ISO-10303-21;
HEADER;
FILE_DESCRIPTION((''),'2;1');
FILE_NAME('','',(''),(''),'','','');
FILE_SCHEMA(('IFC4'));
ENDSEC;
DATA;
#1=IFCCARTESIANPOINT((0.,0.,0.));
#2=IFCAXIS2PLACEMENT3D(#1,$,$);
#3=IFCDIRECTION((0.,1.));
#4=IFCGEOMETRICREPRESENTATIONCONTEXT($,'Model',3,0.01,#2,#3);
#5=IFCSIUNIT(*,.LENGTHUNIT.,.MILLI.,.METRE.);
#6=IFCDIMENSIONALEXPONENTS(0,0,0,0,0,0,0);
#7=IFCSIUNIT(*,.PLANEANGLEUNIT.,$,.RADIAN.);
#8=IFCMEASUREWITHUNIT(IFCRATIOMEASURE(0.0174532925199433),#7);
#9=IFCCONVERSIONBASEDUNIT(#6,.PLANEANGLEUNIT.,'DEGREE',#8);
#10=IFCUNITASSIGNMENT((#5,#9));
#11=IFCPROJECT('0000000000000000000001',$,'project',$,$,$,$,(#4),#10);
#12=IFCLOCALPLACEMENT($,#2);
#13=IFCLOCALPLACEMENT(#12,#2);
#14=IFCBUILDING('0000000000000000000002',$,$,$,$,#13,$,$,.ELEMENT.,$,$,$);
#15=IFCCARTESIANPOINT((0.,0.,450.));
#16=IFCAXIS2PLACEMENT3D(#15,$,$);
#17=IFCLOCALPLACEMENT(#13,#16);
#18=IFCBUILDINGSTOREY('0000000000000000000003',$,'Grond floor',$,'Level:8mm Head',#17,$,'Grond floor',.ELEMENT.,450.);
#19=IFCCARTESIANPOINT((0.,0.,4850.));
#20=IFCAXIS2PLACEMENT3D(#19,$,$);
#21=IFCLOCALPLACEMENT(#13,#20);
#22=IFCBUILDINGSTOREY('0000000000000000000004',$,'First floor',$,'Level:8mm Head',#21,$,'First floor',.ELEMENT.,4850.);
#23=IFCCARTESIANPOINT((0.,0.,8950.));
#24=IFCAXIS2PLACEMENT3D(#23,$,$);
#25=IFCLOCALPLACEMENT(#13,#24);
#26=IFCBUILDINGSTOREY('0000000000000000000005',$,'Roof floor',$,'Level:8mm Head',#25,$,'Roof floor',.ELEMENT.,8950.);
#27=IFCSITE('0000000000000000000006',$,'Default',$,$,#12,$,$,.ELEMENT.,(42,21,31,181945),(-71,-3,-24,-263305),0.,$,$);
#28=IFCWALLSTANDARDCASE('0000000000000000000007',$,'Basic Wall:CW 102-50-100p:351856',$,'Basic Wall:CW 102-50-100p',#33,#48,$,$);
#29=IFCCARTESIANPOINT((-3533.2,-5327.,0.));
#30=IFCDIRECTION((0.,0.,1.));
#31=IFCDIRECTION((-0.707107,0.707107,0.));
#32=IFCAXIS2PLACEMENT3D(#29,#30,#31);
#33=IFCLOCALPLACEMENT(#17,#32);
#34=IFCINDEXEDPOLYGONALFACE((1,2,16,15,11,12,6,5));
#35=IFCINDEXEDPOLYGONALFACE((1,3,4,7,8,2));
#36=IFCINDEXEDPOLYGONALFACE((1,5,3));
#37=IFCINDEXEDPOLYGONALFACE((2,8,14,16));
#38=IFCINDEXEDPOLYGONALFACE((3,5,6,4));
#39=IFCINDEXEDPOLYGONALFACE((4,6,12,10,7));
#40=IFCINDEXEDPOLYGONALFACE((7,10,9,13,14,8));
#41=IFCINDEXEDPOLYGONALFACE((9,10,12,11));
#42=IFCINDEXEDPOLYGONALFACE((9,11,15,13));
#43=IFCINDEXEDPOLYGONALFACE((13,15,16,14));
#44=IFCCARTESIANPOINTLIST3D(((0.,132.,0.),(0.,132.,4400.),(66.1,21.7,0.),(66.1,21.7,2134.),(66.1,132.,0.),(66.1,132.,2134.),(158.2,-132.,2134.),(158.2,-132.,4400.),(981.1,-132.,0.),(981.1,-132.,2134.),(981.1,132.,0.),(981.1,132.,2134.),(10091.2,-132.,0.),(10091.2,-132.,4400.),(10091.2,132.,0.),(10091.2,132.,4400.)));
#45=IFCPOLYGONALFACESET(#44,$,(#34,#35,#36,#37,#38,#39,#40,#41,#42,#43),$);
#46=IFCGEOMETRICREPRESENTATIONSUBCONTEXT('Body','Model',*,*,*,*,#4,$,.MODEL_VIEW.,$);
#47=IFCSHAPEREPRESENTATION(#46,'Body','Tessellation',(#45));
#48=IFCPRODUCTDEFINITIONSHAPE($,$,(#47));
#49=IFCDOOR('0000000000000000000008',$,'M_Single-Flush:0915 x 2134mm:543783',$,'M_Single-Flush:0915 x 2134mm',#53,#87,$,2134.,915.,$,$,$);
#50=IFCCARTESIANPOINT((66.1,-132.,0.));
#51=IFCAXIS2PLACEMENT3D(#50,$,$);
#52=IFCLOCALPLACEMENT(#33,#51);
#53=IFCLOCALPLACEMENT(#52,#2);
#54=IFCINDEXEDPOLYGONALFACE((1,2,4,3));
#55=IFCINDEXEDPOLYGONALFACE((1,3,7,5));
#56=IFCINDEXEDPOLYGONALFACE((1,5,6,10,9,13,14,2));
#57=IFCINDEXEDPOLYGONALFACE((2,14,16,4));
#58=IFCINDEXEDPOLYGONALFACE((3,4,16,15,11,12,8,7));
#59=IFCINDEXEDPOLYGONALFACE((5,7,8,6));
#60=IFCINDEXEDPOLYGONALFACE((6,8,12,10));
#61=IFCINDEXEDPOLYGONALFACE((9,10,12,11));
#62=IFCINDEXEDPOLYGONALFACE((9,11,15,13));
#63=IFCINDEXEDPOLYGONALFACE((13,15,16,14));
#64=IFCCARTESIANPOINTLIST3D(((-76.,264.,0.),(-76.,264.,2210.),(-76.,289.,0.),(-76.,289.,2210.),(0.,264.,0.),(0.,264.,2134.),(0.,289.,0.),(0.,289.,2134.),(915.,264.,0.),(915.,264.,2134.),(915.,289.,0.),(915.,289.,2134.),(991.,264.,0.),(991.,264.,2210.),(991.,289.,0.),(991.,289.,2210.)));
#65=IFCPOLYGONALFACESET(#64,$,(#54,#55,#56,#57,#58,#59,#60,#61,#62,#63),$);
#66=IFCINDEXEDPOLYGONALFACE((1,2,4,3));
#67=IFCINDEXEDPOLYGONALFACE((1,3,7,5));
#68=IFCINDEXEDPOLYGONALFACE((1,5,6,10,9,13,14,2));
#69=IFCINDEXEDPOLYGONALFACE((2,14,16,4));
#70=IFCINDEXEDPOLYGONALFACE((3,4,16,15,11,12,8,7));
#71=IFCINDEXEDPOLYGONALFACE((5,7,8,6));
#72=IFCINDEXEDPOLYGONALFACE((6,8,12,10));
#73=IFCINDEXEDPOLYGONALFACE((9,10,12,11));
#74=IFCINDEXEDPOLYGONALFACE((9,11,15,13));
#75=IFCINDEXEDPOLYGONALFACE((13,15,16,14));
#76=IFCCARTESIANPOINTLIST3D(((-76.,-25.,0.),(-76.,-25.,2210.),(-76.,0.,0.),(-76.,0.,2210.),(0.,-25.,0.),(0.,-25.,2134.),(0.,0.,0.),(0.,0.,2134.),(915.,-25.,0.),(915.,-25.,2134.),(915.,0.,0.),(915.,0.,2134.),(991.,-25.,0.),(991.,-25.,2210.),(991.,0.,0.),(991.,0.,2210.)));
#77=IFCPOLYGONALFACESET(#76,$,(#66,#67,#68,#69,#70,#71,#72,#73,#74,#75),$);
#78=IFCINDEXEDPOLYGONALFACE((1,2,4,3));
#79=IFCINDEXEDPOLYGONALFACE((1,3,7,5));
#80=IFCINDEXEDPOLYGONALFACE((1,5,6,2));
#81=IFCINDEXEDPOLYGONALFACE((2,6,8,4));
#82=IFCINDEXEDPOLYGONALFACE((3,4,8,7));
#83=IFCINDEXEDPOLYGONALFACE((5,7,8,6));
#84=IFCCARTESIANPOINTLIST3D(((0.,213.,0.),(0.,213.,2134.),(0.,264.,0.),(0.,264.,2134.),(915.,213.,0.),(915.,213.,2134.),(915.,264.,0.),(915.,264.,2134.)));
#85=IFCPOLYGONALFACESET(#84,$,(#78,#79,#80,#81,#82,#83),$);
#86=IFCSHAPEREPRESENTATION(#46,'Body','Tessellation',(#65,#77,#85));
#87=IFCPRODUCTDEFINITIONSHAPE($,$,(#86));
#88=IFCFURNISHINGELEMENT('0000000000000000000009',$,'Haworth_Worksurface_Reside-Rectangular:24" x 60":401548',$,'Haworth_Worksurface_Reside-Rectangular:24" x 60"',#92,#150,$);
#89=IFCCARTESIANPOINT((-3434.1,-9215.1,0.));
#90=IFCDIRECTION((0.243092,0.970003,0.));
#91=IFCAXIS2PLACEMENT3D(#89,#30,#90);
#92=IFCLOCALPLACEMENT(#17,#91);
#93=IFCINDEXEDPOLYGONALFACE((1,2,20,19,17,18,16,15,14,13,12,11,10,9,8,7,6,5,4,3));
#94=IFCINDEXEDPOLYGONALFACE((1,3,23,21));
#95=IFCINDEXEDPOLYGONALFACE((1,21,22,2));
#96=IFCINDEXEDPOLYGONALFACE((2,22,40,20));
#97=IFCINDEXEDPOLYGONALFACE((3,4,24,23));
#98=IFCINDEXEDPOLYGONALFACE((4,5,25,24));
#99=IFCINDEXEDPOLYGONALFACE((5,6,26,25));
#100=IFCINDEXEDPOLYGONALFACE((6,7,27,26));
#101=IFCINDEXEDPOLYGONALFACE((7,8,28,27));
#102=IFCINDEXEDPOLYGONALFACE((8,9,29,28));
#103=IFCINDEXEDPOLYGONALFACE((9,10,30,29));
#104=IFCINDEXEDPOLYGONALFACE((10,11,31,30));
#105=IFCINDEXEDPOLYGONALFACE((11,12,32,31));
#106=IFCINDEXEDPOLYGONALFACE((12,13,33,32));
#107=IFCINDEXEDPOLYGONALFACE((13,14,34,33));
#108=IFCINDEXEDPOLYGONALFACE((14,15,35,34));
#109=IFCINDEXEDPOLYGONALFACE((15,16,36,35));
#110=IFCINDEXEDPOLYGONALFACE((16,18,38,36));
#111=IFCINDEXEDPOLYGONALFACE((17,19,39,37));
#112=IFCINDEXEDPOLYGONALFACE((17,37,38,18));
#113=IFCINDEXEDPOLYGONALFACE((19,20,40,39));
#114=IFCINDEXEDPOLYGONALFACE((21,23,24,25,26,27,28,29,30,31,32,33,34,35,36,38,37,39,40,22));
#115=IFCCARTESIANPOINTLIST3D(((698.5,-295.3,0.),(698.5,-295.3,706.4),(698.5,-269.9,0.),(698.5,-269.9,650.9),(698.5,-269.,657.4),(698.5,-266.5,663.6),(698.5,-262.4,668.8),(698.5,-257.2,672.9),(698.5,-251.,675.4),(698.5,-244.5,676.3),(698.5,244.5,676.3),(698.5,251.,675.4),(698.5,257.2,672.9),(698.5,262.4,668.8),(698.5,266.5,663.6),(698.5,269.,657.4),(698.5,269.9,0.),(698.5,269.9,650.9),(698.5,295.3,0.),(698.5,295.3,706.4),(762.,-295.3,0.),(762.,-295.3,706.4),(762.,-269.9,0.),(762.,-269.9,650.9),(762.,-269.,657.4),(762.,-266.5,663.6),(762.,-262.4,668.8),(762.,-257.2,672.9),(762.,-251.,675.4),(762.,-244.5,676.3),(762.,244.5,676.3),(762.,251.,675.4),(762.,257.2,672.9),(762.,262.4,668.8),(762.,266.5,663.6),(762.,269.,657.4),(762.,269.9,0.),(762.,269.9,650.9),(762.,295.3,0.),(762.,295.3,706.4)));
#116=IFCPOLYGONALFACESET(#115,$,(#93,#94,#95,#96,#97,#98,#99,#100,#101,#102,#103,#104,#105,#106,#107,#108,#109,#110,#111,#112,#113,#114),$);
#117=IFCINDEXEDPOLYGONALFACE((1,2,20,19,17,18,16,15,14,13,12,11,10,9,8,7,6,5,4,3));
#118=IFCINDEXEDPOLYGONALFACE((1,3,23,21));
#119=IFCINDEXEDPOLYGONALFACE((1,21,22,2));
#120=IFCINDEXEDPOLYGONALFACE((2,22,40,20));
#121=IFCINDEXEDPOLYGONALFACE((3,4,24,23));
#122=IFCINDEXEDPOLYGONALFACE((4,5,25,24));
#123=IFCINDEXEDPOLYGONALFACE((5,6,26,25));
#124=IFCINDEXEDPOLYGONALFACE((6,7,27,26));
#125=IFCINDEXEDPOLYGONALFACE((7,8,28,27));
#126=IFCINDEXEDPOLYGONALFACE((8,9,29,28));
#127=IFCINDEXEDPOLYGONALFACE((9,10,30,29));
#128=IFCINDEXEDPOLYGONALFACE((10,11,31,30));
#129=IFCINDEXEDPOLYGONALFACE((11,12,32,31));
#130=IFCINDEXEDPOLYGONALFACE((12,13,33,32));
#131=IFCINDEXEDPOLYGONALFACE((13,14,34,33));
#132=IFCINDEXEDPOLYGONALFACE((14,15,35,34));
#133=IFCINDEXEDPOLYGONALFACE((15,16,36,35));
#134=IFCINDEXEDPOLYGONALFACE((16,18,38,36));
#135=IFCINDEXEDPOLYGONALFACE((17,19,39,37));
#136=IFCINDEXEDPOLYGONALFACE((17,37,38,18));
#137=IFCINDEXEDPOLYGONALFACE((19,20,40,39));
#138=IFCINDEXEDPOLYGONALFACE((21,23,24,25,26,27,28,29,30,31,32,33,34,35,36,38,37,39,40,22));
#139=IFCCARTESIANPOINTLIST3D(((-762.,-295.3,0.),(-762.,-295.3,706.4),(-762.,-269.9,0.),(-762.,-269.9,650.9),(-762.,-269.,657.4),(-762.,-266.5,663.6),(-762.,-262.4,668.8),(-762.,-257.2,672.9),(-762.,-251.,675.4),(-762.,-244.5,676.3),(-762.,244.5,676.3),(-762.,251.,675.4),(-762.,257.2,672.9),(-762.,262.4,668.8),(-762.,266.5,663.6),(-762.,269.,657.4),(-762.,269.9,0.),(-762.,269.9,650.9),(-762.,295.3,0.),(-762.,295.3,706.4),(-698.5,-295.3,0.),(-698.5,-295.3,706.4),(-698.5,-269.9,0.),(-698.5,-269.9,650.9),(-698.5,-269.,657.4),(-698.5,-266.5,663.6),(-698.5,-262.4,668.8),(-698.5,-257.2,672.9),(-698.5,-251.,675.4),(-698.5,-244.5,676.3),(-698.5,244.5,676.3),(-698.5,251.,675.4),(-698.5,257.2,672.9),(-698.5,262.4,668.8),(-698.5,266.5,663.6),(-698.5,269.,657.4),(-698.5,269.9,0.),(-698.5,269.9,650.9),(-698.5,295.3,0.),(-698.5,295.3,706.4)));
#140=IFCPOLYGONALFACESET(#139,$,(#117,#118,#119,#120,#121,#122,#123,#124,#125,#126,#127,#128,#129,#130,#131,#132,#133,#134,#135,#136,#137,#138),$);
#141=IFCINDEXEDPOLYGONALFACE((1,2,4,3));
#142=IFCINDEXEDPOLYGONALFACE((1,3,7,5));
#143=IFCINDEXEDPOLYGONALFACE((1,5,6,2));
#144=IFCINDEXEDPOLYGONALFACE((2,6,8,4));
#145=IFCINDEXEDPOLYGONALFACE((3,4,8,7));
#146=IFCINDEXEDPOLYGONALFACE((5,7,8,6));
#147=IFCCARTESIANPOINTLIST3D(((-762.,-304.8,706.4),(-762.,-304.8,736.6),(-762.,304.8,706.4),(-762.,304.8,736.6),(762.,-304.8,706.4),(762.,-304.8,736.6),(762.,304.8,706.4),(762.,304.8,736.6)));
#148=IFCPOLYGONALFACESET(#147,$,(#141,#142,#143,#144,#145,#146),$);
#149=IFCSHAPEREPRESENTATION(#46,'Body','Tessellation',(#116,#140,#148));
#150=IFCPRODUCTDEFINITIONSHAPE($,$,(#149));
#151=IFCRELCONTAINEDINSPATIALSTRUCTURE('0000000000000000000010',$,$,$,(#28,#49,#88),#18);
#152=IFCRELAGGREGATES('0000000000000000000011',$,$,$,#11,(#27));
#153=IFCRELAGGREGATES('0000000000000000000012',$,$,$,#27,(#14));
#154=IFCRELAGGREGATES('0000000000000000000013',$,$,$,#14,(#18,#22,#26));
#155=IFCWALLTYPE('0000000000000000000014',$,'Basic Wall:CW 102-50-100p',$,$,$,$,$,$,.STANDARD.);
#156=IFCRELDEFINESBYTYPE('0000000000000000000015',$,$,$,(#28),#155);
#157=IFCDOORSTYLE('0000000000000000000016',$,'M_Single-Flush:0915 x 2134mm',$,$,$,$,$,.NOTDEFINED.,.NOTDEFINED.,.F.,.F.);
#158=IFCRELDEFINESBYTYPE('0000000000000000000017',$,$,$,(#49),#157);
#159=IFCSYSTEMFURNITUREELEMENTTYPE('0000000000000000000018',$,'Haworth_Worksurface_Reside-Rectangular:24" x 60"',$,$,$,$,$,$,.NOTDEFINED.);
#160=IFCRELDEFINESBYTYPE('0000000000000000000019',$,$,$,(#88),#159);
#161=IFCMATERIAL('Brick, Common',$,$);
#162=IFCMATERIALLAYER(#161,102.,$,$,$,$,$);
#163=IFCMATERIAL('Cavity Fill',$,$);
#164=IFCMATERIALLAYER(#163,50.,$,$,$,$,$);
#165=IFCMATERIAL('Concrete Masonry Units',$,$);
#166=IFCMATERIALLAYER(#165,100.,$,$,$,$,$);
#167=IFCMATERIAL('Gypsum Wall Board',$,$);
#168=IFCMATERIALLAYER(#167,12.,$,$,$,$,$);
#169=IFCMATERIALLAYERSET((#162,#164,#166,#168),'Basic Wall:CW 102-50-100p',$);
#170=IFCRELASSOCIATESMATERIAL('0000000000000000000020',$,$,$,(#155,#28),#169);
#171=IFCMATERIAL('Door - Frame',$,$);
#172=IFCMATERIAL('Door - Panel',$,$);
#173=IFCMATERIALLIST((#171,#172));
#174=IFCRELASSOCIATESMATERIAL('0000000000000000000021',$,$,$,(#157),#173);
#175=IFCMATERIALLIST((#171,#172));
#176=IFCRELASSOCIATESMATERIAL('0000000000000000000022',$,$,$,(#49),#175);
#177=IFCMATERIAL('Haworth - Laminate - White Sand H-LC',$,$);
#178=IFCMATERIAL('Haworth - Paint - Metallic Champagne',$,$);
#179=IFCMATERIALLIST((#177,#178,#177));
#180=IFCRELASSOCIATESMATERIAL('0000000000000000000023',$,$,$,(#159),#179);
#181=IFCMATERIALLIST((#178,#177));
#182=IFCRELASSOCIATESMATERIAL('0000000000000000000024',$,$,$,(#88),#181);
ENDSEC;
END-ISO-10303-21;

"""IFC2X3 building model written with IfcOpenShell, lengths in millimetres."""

from ifc_helpers import new_model, entity, si_unit, converted_unit, direction, frame, frame_2d, origin, origin_2d_with_axis, place, context, subcontext, project, spatial, polyline, circle_curve, parameter, trimmed, segment, composite_curve, rectangle, outline, extrude, source, transform, mapped, material, material_list, layer, layer_set, layer_usage, type_object, type_shapes, element, fill, save


model = new_model("IFC2X3")

# Units and contexts
model_context = context("Model", 3, precision=0.01, world=origin(), true_north=direction((0.0, 1.0)))
body_context = subcontext(model_context, "Body", "Model", "MODEL_VIEW")
ifc_project = project(units=[si_unit("LENGTHUNIT", "METRE", prefix="MILLI"), converted_unit("PLANEANGLEUNIT", "DEGREE", entity("IfcRatioMeasure", 0.0174532925199433), si_unit("PLANEANGLEUNIT", "RADIAN"), dimensions=[0, 0, 0, 0, 0, 0, 0])], contexts=[model_context])

# Site, building, storey
site_placement = place(None, origin())
site = spatial("IfcSite", under=ifc_project, at=site_placement, Name="Default", CompositionType="ELEMENT", RefLatitude=(42, 21, 31, 181945), RefLongitude=(-71, -3, -24, -263305), RefElevation=0.0)
building_placement = place(site_placement, origin())
building = spatial("IfcBuilding", under=site, at=building_placement, CompositionType="ELEMENT")
storey_1_placement = place(building_placement, frame((0.0, 0.0, 450.0)))
storey_1 = spatial("IfcBuildingStorey", under=building, at=storey_1_placement, Name="Grond floor", ObjectType="Level:8mm Head", LongName="Grond floor", CompositionType="ELEMENT", Elevation=450.0)

# Wall, opening, door
ifc_material_1 = material(Name="Brick, Common")
ifc_layer_1 = layer(ifc_material_1, 102.0)
ifc_material_2 = material(Name="Cavity Fill")
ifc_layer_2 = layer(ifc_material_2, 50.0)
ifc_material_3 = material(Name="Concrete Masonry Units")
ifc_layer_3 = layer(ifc_material_3, 100.0)
ifc_material_4 = material(Name="Gypsum Wall Board")
ifc_layer_4 = layer(ifc_material_4, 12.0)
ifc_layer_set_1 = layer_set([ifc_layer_1, ifc_layer_2, ifc_layer_3, ifc_layer_4], Name="Basic Wall:CW 102-50-100p")
ifc_layer_usage_1 = layer_usage(ifc_layer_set_1, "AXIS2", "NEGATIVE", 132.0)
wall_type_1 = type_object("IfcWallType", Name="Basic Wall:CW 102-50-100p", PredefinedType="STANDARD", material=ifc_layer_set_1)
wall_1_placement = place(storey_1_placement, frame((-3533.2, -5327.0, 0.0), z_axis=(0.0, 0.0, 1.0), x_axis=(-0.707107, 0.707107, 0.0)))
wall_1 = element("IfcWallStandardCase", 1, at=wall_1_placement, inside=storey_1, type_object=wall_type_1, material=ifc_layer_usage_1, Name="Basic Wall:CW 102-50-100p:351856", ObjectType="Basic Wall:CW 102-50-100p", context=body_context, shape_type="SweptSolid", body=[
    extrude(outline(polyline([(158.2, -132.0), (3970.5, -132.0), (4049.5, -132.0), (5570.5, -132.0), (5649.5, -132.0), (7170.5, -132.0), (7249.5, -132.0), (8831.7, -132.0), (8910.7, -132.0), (10091.2, -132.0), (10091.2, 114.0), (10091.2, 132.0), (7869.2, 132.0), (7605.2, 132.0), (0.0, 132.0), (158.2, -132.0)])), origin(), (0.0, 0.0, 1.0), 4400.0),
])
opening_1_placement = place(wall_1_placement, frame((66.1, -132.0, 0.0)))
opening_1 = element("IfcOpeningElement", 2, at=opening_1_placement, cuts=wall_1, ObjectType="Opening", context=body_context, shape_type="SweptSolid", body=[
    extrude(rectangle(XDim=915.0, YDim=2134.0, at=frame_2d((1067.0, 457.5), x_axis=(0.0, -1.0))), frame((0.0, 0.0, 0.0), z_axis=(0.0, 1.0, 0.0), x_axis=(0.0, 0.0, 1.0)), (0.0, 0.0, 1.0), 264.0),
])
ifc_material_5 = material(Name="Door - Frame")
ifc_material_6 = material(Name="Door - Panel")
ifc_material_list_1 = material_list([ifc_material_5, ifc_material_6])
ifc_material_list_2 = material_list([ifc_material_5, ifc_material_6])
door_style_1 = type_object("IfcDoorStyle", Name="M_Single-Flush:0915 x 2134mm", ConstructionType="NOTDEFINED", OperationType="NOTDEFINED", ParameterTakesPrecedence=False, Sizeable=False, material=ifc_material_list_2)
shared_shape_1 = source(origin(), body_context, "Body", "SweptSolid", [
    extrude(outline(polyline([(-533.5, -1124.0), (533.5, -1124.0), (533.5, 1086.0), (457.5, 1086.0), (457.5, -1048.0), (-457.5, -1048.0), (-457.5, 1086.0), (-533.5, 1086.0), (-533.5, -1124.0)])), frame((457.5, 289.0, 1086.0), z_axis=(0.0, -1.0, 0.0), x_axis=(-1.0, 0.0, 0.0)), (0.0, 0.0, 1.0), 25.0),
    extrude(outline(polyline([(-1124.0, -533.5), (1086.0, -533.5), (1086.0, -457.5), (-1048.0, -457.5), (-1048.0, 457.5), (1086.0, 457.5), (1086.0, 533.5), (-1124.0, 533.5), (-1124.0, -533.5)])), frame((457.5, 0.0, 1086.0), z_axis=(0.0, -1.0, 0.0), x_axis=(0.0, 0.0, -1.0)), (0.0, 0.0, 1.0), 25.0),
    extrude(rectangle(XDim=915.0, YDim=51.0, at=frame_2d((0.0, 0.0), x_axis=(1.0, 0.0))), frame((457.5, 238.5, 0.0)), (0.0, 0.0, 1.0), 2134.0),
])
type_shapes(door_style_1, [shared_shape_1])
door_1_placement = place(opening_1_placement, origin())
door_1 = element("IfcDoor", 3, at=door_1_placement, inside=storey_1, type_object=door_style_1, material=ifc_material_list_1, Name="M_Single-Flush:0915 x 2134mm:543783", ObjectType="M_Single-Flush:0915 x 2134mm", OverallHeight=2134.0, OverallWidth=915.0, context=body_context, shape_type="MappedRepresentation", body=[
    mapped(shared_shape_1, transform((0.0, 0.0, 0.0), scale=1.0)),
])
fill(opening_1, door_1)

# Shared definitions
storey_2_placement = place(building_placement, frame((0.0, 0.0, 4850.0)))
storey_2 = spatial("IfcBuildingStorey", under=building, at=storey_2_placement, Name="First floor", ObjectType="Level:8mm Head", LongName="First floor", CompositionType="ELEMENT", Elevation=4850.0)

# Shared definitions
storey_3_placement = place(building_placement, frame((0.0, 0.0, 8950.0)))
storey_3 = spatial("IfcBuildingStorey", under=building, at=storey_3_placement, Name="Roof floor", ObjectType="Level:8mm Head", LongName="Roof floor", CompositionType="ELEMENT", Elevation=8950.0)

# Furnishing element
ifc_material_7 = material(Name="Haworth - Paint - Metallic Champagne")
ifc_material_8 = material(Name="Haworth - Laminate - White Sand H-LC")
ifc_material_list_3 = material_list([ifc_material_8, ifc_material_7, ifc_material_8])
system_furniture_element_type = type_object("IfcSystemFurnitureElementType", Name="Haworth_Worksurface_Reside-Rectangular:24\" x 60\"", material=ifc_material_list_3)
shared_shape_2 = source(origin(), body_context, "Body", "SweptSolid", [
    extrude(outline(composite_curve([segment(polyline([(-244.2, 269.9), (406.7, 269.9)]), True, "CONTINUOUS"), segment(polyline([(406.7, 269.9), (406.7, 295.3)]), True, "CONTINUOUS"), segment(polyline([(406.7, 295.3), (-299.7, 295.3)]), True, "CONTINUOUS"), segment(polyline([(-299.7, 295.3), (-299.7, -295.3)]), True, "CONTINUOUS"), segment(polyline([(-299.7, -295.3), (406.7, -295.3)]), True, "CONTINUOUS"), segment(polyline([(406.7, -295.3), (406.7, -269.9)]), True, "CONTINUOUS"), segment(polyline([(406.7, -269.9), (-244.2, -269.9)]), True, "CONTINUOUS"), segment(trimmed(circle_curve(frame_2d((-244.2, -244.5), x_axis=(0.0, 1.0)), 25.4), [parameter(90.0)], [parameter(180.0)], True, "PARAMETER"), False, "CONTINUOUS"), segment(polyline([(-269.6, -244.5), (-269.6, 244.5)]), True, "CONTINUOUS"), segment(trimmed(circle_curve(frame_2d((-244.2, 244.5), x_axis=(0.0, 1.0)), 25.4), [parameter(0.0)], [parameter(90.0)], True, "PARAMETER"), False, "CONTINUOUS")], self_intersect=False)), frame((698.5, 0.0, 406.7), z_axis=(1.0, 0.0, 0.0), x_axis=(0.0, 0.0, -1.0)), (0.0, 0.0, 1.0), 63.5),
    extrude(outline(composite_curve([segment(polyline([(-244.2, 269.9), (406.7, 269.9)]), True, "CONTINUOUS"), segment(polyline([(406.7, 269.9), (406.7, 295.3)]), True, "CONTINUOUS"), segment(polyline([(406.7, 295.3), (-299.7, 295.3)]), True, "CONTINUOUS"), segment(polyline([(-299.7, 295.3), (-299.7, -295.3)]), True, "CONTINUOUS"), segment(polyline([(-299.7, -295.3), (406.7, -295.3)]), True, "CONTINUOUS"), segment(polyline([(406.7, -295.3), (406.7, -269.9)]), True, "CONTINUOUS"), segment(polyline([(406.7, -269.9), (-244.2, -269.9)]), True, "CONTINUOUS"), segment(trimmed(circle_curve(frame_2d((-244.2, -244.5), x_axis=(0.0, 1.0)), 25.4), [parameter(90.0)], [parameter(180.0)], True, "PARAMETER"), False, "CONTINUOUS"), segment(polyline([(-269.6, -244.5), (-269.6, 244.5)]), True, "CONTINUOUS"), segment(trimmed(circle_curve(frame_2d((-244.2, 244.5), x_axis=(0.0, 1.0)), 25.4), [parameter(0.0)], [parameter(90.0)], True, "PARAMETER"), False, "CONTINUOUS")], self_intersect=False)), frame((-762.0, 0.0, 406.7), z_axis=(1.0, 0.0, 0.0), x_axis=(0.0, 0.0, -1.0)), (0.0, 0.0, 1.0), 63.5),
    extrude(rectangle(XDim=1524.0, YDim=609.6, at=origin_2d_with_axis()), frame((0.0, 0.0, 706.4), z_axis=(0.0, 0.0, 1.0), x_axis=(-1.0, 0.0, 0.0)), (0.0, 0.0, 1.0), 30.2),
])
type_shapes(system_furniture_element_type, [shared_shape_2])
ifc_material_list_4 = material_list([ifc_material_7, ifc_material_8])
furnishing_1_placement = place(storey_1_placement, frame((-3434.1, -9215.1, 0.0), z_axis=(0.0, 0.0, 1.0), x_axis=(0.243092, 0.970003, 0.0)))
element("IfcFurnishingElement", 4, at=furnishing_1_placement, inside=storey_1, type_object=system_furniture_element_type, material=ifc_material_list_4, Name="Haworth_Worksurface_Reside-Rectangular:24\" x 60\":401548", ObjectType="Haworth_Worksurface_Reside-Rectangular:24\" x 60\"", context=body_context, shape_type="MappedRepresentation", body=[
    mapped(shared_shape_2, transform((0.0, 0.0, 0.0), scale=1.0)),
])

save(model, "model.ifc")
